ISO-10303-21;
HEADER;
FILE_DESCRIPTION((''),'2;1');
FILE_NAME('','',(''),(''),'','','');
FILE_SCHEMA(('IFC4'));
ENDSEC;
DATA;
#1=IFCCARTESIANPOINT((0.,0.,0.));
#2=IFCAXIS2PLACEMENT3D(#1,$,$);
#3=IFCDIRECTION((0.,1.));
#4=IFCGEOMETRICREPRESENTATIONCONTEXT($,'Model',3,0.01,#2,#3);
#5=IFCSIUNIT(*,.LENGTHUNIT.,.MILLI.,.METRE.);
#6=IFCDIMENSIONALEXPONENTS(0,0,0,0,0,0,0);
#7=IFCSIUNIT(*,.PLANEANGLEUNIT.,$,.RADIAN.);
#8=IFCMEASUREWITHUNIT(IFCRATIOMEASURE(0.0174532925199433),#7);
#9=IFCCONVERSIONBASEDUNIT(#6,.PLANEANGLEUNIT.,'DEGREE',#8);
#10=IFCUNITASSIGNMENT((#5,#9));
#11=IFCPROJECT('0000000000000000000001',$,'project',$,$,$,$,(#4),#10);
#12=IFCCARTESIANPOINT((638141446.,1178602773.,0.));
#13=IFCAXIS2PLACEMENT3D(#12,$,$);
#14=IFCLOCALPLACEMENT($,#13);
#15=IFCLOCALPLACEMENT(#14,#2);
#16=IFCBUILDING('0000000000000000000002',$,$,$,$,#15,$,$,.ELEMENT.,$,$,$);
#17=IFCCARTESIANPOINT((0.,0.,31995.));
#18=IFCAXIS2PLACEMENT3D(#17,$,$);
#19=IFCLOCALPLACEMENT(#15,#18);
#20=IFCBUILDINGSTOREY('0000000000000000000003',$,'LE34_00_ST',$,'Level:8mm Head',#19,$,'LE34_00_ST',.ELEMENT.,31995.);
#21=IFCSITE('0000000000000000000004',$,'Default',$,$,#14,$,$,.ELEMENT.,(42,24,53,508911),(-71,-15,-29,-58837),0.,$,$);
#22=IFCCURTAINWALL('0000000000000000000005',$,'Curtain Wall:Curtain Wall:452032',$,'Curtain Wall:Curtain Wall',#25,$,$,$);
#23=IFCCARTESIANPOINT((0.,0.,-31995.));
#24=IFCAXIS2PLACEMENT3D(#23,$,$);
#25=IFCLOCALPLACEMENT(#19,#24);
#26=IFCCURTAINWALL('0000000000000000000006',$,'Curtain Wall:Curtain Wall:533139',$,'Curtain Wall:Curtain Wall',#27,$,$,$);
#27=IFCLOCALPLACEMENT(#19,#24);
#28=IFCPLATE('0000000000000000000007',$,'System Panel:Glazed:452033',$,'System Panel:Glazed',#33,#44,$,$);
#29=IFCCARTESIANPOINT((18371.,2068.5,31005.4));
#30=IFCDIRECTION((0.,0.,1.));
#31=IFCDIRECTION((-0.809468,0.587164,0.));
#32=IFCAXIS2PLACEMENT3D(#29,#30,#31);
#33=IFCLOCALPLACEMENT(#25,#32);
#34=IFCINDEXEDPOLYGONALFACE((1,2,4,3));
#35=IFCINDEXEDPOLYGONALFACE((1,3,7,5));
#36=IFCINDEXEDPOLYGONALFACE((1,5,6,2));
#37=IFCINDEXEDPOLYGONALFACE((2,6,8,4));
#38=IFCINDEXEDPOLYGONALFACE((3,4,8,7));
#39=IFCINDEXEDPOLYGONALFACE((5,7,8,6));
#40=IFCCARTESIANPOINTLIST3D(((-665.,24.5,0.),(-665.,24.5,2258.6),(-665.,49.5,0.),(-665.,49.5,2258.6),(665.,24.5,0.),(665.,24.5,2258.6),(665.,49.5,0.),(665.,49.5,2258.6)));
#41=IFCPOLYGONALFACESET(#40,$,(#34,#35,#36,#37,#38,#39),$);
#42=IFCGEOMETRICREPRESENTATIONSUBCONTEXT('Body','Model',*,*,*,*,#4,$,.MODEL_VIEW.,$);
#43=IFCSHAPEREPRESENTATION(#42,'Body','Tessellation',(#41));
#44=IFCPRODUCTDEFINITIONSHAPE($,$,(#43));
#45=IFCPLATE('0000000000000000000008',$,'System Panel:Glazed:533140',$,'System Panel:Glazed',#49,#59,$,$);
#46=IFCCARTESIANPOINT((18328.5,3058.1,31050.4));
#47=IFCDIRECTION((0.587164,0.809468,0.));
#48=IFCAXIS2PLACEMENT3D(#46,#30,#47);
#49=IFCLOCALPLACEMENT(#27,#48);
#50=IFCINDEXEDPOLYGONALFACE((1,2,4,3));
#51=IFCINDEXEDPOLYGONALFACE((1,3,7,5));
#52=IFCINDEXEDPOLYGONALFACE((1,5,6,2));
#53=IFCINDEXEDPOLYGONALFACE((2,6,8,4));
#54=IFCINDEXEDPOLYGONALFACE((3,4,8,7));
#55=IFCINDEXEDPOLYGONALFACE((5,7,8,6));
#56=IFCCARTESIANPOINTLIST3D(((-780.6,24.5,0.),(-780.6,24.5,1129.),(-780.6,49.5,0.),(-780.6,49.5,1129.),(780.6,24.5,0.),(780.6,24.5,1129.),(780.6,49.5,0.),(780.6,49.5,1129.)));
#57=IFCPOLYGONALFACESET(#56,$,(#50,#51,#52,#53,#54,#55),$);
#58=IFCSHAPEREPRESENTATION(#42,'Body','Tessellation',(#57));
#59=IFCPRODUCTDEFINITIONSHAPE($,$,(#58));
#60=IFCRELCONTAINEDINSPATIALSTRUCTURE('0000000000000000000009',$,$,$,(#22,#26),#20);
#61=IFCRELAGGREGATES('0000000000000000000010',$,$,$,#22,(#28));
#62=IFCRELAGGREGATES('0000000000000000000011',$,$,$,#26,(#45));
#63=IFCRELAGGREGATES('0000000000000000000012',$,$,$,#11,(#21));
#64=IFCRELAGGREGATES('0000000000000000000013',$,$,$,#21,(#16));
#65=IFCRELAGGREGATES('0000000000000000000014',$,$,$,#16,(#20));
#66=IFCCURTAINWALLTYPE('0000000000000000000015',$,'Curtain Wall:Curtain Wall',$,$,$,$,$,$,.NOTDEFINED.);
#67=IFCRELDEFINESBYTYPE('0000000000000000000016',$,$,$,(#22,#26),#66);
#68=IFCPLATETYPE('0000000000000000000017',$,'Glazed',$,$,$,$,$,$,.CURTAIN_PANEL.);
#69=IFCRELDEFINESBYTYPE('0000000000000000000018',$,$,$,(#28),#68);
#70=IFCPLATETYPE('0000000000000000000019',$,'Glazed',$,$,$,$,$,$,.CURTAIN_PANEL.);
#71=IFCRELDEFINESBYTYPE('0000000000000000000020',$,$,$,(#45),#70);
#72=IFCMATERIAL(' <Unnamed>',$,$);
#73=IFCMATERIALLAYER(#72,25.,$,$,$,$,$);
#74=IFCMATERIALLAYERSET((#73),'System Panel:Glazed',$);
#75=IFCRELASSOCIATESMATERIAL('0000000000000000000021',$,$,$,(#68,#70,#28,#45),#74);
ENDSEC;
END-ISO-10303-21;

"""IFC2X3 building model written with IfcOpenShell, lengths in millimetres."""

from ifc_helpers import new_model, entity, si_unit, converted_unit, direction, frame, frame_2d, origin, origin_2d_with_axis, place, context, subcontext, project, spatial, rectangle, extrude, source, transform, mapped, material, layer, layer_set, layer_usage, type_object, type_shapes, element, aggregate, save


model = new_model("IFC2X3")

# Units and contexts
model_context = context("Model", 3, precision=0.01, world=origin(), true_north=direction((0.0, 1.0)))
body_context = subcontext(model_context, "Body", "Model", "MODEL_VIEW")
ifc_project = project(units=[si_unit("LENGTHUNIT", "METRE", prefix="MILLI"), converted_unit("PLANEANGLEUNIT", "DEGREE", entity("IfcRatioMeasure", 0.0174532925199433), si_unit("PLANEANGLEUNIT", "RADIAN"), dimensions=[0, 0, 0, 0, 0, 0, 0])], contexts=[model_context])

# Site, building, storey
site_placement = place(None, frame((638141446.0, 1178602773.0, 0.0)))
site = spatial("IfcSite", under=ifc_project, at=site_placement, Name="Default", CompositionType="ELEMENT", RefLatitude=(42, 24, 53, 508911), RefLongitude=(-71, -15, -29, -58837), RefElevation=0.0)
building_placement = place(site_placement, origin())
building = spatial("IfcBuilding", under=site, at=building_placement, CompositionType="ELEMENT")
storey_placement = place(building_placement, frame((0.0, 0.0, 31995.0)))
storey = spatial("IfcBuildingStorey", under=building, at=storey_placement, Name="LE34_00_ST", ObjectType="Level:8mm Head", LongName="LE34_00_ST", CompositionType="ELEMENT", Elevation=31995.0)

# Curtain wall
curtain_wall_type = type_object("IfcCurtainWallType", Name="Curtain Wall:Curtain Wall", PredefinedType="NOTDEFINED")
curtain_wall_1_placement = place(storey_placement, frame((0.0, 0.0, -31995.0)))
curtain_wall_1 = element("IfcCurtainWall", 1, at=curtain_wall_1_placement, inside=storey, type_object=curtain_wall_type, Name="Curtain Wall:Curtain Wall:452032", ObjectType="Curtain Wall:Curtain Wall")

# Curtain wall
curtain_wall_2_placement = place(storey_placement, frame((0.0, 0.0, -31995.0)))
curtain_wall_2 = element("IfcCurtainWall", 2, at=curtain_wall_2_placement, inside=storey, type_object=curtain_wall_type, Name="Curtain Wall:Curtain Wall:533139", ObjectType="Curtain Wall:Curtain Wall")

# Plates
ifc_material_1 = material(Name=" <Unnamed>")
ifc_layer_1 = layer(ifc_material_1, 25.0)
ifc_layer_set_1 = layer_set([ifc_layer_1], Name="System Panel:Glazed")
ifc_layer_usage_1 = layer_usage(ifc_layer_set_1, "AXIS3", "POSITIVE", 0.1)
plate_type_1 = type_object("IfcPlateType", Name="Glazed", PredefinedType="CURTAIN_PANEL", material=ifc_layer_set_1)
shared_shape_1 = source(origin(), body_context, "Body", "SweptSolid", [
    extrude(rectangle(XDim=25.0, YDim=1330.0, at=origin_2d_with_axis()), frame((0.0, 37.0, 0.0), z_axis=(0.0, 0.0, 1.0), x_axis=(0.0, 1.0, 0.0)), (0.0, 0.0, 1.0), 2258.6),
])
type_shapes(plate_type_1, [shared_shape_1])
plate_1_placement = place(curtain_wall_1_placement, frame((18371.0, 2068.5, 31005.4), z_axis=(0.0, 0.0, 1.0), x_axis=(-0.809468, 0.587164, 0.0)))
plate_1 = element("IfcPlate", 3, at=plate_1_placement, type_object=plate_type_1, material=ifc_layer_usage_1, Name="System Panel:Glazed:452033", ObjectType="System Panel:Glazed", context=body_context, shape_type="MappedRepresentation", body=[
    mapped(shared_shape_1, transform((0.0, 0.0, 0.0), scale=1.0)),
])
aggregate(curtain_wall_1, [plate_1])
ifc_layer_usage_2 = layer_usage(ifc_layer_set_1, "AXIS3", "POSITIVE", 0.1)
plate_type_2 = type_object("IfcPlateType", Name="Glazed", PredefinedType="CURTAIN_PANEL", material=ifc_layer_set_1)
shared_shape_2 = source(origin(), body_context, "Body", "SweptSolid", [
    extrude(rectangle(XDim=25.0, YDim=1561.3, at=frame_2d((0.0, 0.0), x_axis=(1.0, 0.0))), frame((0.0, 37.0, 0.0), z_axis=(0.0, 0.0, 1.0), x_axis=(0.0, 1.0, 0.0)), (0.0, 0.0, 1.0), 1129.0),
])
type_shapes(plate_type_2, [shared_shape_2])
plate_2_placement = place(curtain_wall_2_placement, frame((18328.5, 3058.1, 31050.4), z_axis=(0.0, 0.0, 1.0), x_axis=(0.587164, 0.809468, 0.0)))
plate_2 = element("IfcPlate", 4, at=plate_2_placement, type_object=plate_type_2, material=ifc_layer_usage_2, Name="System Panel:Glazed:533140", ObjectType="System Panel:Glazed", context=body_context, shape_type="MappedRepresentation", body=[
    mapped(shared_shape_2, transform((0.0, 0.0, 0.0), scale=1.0)),
])
aggregate(curtain_wall_2, [plate_2])

save(model, "model.ifc")
